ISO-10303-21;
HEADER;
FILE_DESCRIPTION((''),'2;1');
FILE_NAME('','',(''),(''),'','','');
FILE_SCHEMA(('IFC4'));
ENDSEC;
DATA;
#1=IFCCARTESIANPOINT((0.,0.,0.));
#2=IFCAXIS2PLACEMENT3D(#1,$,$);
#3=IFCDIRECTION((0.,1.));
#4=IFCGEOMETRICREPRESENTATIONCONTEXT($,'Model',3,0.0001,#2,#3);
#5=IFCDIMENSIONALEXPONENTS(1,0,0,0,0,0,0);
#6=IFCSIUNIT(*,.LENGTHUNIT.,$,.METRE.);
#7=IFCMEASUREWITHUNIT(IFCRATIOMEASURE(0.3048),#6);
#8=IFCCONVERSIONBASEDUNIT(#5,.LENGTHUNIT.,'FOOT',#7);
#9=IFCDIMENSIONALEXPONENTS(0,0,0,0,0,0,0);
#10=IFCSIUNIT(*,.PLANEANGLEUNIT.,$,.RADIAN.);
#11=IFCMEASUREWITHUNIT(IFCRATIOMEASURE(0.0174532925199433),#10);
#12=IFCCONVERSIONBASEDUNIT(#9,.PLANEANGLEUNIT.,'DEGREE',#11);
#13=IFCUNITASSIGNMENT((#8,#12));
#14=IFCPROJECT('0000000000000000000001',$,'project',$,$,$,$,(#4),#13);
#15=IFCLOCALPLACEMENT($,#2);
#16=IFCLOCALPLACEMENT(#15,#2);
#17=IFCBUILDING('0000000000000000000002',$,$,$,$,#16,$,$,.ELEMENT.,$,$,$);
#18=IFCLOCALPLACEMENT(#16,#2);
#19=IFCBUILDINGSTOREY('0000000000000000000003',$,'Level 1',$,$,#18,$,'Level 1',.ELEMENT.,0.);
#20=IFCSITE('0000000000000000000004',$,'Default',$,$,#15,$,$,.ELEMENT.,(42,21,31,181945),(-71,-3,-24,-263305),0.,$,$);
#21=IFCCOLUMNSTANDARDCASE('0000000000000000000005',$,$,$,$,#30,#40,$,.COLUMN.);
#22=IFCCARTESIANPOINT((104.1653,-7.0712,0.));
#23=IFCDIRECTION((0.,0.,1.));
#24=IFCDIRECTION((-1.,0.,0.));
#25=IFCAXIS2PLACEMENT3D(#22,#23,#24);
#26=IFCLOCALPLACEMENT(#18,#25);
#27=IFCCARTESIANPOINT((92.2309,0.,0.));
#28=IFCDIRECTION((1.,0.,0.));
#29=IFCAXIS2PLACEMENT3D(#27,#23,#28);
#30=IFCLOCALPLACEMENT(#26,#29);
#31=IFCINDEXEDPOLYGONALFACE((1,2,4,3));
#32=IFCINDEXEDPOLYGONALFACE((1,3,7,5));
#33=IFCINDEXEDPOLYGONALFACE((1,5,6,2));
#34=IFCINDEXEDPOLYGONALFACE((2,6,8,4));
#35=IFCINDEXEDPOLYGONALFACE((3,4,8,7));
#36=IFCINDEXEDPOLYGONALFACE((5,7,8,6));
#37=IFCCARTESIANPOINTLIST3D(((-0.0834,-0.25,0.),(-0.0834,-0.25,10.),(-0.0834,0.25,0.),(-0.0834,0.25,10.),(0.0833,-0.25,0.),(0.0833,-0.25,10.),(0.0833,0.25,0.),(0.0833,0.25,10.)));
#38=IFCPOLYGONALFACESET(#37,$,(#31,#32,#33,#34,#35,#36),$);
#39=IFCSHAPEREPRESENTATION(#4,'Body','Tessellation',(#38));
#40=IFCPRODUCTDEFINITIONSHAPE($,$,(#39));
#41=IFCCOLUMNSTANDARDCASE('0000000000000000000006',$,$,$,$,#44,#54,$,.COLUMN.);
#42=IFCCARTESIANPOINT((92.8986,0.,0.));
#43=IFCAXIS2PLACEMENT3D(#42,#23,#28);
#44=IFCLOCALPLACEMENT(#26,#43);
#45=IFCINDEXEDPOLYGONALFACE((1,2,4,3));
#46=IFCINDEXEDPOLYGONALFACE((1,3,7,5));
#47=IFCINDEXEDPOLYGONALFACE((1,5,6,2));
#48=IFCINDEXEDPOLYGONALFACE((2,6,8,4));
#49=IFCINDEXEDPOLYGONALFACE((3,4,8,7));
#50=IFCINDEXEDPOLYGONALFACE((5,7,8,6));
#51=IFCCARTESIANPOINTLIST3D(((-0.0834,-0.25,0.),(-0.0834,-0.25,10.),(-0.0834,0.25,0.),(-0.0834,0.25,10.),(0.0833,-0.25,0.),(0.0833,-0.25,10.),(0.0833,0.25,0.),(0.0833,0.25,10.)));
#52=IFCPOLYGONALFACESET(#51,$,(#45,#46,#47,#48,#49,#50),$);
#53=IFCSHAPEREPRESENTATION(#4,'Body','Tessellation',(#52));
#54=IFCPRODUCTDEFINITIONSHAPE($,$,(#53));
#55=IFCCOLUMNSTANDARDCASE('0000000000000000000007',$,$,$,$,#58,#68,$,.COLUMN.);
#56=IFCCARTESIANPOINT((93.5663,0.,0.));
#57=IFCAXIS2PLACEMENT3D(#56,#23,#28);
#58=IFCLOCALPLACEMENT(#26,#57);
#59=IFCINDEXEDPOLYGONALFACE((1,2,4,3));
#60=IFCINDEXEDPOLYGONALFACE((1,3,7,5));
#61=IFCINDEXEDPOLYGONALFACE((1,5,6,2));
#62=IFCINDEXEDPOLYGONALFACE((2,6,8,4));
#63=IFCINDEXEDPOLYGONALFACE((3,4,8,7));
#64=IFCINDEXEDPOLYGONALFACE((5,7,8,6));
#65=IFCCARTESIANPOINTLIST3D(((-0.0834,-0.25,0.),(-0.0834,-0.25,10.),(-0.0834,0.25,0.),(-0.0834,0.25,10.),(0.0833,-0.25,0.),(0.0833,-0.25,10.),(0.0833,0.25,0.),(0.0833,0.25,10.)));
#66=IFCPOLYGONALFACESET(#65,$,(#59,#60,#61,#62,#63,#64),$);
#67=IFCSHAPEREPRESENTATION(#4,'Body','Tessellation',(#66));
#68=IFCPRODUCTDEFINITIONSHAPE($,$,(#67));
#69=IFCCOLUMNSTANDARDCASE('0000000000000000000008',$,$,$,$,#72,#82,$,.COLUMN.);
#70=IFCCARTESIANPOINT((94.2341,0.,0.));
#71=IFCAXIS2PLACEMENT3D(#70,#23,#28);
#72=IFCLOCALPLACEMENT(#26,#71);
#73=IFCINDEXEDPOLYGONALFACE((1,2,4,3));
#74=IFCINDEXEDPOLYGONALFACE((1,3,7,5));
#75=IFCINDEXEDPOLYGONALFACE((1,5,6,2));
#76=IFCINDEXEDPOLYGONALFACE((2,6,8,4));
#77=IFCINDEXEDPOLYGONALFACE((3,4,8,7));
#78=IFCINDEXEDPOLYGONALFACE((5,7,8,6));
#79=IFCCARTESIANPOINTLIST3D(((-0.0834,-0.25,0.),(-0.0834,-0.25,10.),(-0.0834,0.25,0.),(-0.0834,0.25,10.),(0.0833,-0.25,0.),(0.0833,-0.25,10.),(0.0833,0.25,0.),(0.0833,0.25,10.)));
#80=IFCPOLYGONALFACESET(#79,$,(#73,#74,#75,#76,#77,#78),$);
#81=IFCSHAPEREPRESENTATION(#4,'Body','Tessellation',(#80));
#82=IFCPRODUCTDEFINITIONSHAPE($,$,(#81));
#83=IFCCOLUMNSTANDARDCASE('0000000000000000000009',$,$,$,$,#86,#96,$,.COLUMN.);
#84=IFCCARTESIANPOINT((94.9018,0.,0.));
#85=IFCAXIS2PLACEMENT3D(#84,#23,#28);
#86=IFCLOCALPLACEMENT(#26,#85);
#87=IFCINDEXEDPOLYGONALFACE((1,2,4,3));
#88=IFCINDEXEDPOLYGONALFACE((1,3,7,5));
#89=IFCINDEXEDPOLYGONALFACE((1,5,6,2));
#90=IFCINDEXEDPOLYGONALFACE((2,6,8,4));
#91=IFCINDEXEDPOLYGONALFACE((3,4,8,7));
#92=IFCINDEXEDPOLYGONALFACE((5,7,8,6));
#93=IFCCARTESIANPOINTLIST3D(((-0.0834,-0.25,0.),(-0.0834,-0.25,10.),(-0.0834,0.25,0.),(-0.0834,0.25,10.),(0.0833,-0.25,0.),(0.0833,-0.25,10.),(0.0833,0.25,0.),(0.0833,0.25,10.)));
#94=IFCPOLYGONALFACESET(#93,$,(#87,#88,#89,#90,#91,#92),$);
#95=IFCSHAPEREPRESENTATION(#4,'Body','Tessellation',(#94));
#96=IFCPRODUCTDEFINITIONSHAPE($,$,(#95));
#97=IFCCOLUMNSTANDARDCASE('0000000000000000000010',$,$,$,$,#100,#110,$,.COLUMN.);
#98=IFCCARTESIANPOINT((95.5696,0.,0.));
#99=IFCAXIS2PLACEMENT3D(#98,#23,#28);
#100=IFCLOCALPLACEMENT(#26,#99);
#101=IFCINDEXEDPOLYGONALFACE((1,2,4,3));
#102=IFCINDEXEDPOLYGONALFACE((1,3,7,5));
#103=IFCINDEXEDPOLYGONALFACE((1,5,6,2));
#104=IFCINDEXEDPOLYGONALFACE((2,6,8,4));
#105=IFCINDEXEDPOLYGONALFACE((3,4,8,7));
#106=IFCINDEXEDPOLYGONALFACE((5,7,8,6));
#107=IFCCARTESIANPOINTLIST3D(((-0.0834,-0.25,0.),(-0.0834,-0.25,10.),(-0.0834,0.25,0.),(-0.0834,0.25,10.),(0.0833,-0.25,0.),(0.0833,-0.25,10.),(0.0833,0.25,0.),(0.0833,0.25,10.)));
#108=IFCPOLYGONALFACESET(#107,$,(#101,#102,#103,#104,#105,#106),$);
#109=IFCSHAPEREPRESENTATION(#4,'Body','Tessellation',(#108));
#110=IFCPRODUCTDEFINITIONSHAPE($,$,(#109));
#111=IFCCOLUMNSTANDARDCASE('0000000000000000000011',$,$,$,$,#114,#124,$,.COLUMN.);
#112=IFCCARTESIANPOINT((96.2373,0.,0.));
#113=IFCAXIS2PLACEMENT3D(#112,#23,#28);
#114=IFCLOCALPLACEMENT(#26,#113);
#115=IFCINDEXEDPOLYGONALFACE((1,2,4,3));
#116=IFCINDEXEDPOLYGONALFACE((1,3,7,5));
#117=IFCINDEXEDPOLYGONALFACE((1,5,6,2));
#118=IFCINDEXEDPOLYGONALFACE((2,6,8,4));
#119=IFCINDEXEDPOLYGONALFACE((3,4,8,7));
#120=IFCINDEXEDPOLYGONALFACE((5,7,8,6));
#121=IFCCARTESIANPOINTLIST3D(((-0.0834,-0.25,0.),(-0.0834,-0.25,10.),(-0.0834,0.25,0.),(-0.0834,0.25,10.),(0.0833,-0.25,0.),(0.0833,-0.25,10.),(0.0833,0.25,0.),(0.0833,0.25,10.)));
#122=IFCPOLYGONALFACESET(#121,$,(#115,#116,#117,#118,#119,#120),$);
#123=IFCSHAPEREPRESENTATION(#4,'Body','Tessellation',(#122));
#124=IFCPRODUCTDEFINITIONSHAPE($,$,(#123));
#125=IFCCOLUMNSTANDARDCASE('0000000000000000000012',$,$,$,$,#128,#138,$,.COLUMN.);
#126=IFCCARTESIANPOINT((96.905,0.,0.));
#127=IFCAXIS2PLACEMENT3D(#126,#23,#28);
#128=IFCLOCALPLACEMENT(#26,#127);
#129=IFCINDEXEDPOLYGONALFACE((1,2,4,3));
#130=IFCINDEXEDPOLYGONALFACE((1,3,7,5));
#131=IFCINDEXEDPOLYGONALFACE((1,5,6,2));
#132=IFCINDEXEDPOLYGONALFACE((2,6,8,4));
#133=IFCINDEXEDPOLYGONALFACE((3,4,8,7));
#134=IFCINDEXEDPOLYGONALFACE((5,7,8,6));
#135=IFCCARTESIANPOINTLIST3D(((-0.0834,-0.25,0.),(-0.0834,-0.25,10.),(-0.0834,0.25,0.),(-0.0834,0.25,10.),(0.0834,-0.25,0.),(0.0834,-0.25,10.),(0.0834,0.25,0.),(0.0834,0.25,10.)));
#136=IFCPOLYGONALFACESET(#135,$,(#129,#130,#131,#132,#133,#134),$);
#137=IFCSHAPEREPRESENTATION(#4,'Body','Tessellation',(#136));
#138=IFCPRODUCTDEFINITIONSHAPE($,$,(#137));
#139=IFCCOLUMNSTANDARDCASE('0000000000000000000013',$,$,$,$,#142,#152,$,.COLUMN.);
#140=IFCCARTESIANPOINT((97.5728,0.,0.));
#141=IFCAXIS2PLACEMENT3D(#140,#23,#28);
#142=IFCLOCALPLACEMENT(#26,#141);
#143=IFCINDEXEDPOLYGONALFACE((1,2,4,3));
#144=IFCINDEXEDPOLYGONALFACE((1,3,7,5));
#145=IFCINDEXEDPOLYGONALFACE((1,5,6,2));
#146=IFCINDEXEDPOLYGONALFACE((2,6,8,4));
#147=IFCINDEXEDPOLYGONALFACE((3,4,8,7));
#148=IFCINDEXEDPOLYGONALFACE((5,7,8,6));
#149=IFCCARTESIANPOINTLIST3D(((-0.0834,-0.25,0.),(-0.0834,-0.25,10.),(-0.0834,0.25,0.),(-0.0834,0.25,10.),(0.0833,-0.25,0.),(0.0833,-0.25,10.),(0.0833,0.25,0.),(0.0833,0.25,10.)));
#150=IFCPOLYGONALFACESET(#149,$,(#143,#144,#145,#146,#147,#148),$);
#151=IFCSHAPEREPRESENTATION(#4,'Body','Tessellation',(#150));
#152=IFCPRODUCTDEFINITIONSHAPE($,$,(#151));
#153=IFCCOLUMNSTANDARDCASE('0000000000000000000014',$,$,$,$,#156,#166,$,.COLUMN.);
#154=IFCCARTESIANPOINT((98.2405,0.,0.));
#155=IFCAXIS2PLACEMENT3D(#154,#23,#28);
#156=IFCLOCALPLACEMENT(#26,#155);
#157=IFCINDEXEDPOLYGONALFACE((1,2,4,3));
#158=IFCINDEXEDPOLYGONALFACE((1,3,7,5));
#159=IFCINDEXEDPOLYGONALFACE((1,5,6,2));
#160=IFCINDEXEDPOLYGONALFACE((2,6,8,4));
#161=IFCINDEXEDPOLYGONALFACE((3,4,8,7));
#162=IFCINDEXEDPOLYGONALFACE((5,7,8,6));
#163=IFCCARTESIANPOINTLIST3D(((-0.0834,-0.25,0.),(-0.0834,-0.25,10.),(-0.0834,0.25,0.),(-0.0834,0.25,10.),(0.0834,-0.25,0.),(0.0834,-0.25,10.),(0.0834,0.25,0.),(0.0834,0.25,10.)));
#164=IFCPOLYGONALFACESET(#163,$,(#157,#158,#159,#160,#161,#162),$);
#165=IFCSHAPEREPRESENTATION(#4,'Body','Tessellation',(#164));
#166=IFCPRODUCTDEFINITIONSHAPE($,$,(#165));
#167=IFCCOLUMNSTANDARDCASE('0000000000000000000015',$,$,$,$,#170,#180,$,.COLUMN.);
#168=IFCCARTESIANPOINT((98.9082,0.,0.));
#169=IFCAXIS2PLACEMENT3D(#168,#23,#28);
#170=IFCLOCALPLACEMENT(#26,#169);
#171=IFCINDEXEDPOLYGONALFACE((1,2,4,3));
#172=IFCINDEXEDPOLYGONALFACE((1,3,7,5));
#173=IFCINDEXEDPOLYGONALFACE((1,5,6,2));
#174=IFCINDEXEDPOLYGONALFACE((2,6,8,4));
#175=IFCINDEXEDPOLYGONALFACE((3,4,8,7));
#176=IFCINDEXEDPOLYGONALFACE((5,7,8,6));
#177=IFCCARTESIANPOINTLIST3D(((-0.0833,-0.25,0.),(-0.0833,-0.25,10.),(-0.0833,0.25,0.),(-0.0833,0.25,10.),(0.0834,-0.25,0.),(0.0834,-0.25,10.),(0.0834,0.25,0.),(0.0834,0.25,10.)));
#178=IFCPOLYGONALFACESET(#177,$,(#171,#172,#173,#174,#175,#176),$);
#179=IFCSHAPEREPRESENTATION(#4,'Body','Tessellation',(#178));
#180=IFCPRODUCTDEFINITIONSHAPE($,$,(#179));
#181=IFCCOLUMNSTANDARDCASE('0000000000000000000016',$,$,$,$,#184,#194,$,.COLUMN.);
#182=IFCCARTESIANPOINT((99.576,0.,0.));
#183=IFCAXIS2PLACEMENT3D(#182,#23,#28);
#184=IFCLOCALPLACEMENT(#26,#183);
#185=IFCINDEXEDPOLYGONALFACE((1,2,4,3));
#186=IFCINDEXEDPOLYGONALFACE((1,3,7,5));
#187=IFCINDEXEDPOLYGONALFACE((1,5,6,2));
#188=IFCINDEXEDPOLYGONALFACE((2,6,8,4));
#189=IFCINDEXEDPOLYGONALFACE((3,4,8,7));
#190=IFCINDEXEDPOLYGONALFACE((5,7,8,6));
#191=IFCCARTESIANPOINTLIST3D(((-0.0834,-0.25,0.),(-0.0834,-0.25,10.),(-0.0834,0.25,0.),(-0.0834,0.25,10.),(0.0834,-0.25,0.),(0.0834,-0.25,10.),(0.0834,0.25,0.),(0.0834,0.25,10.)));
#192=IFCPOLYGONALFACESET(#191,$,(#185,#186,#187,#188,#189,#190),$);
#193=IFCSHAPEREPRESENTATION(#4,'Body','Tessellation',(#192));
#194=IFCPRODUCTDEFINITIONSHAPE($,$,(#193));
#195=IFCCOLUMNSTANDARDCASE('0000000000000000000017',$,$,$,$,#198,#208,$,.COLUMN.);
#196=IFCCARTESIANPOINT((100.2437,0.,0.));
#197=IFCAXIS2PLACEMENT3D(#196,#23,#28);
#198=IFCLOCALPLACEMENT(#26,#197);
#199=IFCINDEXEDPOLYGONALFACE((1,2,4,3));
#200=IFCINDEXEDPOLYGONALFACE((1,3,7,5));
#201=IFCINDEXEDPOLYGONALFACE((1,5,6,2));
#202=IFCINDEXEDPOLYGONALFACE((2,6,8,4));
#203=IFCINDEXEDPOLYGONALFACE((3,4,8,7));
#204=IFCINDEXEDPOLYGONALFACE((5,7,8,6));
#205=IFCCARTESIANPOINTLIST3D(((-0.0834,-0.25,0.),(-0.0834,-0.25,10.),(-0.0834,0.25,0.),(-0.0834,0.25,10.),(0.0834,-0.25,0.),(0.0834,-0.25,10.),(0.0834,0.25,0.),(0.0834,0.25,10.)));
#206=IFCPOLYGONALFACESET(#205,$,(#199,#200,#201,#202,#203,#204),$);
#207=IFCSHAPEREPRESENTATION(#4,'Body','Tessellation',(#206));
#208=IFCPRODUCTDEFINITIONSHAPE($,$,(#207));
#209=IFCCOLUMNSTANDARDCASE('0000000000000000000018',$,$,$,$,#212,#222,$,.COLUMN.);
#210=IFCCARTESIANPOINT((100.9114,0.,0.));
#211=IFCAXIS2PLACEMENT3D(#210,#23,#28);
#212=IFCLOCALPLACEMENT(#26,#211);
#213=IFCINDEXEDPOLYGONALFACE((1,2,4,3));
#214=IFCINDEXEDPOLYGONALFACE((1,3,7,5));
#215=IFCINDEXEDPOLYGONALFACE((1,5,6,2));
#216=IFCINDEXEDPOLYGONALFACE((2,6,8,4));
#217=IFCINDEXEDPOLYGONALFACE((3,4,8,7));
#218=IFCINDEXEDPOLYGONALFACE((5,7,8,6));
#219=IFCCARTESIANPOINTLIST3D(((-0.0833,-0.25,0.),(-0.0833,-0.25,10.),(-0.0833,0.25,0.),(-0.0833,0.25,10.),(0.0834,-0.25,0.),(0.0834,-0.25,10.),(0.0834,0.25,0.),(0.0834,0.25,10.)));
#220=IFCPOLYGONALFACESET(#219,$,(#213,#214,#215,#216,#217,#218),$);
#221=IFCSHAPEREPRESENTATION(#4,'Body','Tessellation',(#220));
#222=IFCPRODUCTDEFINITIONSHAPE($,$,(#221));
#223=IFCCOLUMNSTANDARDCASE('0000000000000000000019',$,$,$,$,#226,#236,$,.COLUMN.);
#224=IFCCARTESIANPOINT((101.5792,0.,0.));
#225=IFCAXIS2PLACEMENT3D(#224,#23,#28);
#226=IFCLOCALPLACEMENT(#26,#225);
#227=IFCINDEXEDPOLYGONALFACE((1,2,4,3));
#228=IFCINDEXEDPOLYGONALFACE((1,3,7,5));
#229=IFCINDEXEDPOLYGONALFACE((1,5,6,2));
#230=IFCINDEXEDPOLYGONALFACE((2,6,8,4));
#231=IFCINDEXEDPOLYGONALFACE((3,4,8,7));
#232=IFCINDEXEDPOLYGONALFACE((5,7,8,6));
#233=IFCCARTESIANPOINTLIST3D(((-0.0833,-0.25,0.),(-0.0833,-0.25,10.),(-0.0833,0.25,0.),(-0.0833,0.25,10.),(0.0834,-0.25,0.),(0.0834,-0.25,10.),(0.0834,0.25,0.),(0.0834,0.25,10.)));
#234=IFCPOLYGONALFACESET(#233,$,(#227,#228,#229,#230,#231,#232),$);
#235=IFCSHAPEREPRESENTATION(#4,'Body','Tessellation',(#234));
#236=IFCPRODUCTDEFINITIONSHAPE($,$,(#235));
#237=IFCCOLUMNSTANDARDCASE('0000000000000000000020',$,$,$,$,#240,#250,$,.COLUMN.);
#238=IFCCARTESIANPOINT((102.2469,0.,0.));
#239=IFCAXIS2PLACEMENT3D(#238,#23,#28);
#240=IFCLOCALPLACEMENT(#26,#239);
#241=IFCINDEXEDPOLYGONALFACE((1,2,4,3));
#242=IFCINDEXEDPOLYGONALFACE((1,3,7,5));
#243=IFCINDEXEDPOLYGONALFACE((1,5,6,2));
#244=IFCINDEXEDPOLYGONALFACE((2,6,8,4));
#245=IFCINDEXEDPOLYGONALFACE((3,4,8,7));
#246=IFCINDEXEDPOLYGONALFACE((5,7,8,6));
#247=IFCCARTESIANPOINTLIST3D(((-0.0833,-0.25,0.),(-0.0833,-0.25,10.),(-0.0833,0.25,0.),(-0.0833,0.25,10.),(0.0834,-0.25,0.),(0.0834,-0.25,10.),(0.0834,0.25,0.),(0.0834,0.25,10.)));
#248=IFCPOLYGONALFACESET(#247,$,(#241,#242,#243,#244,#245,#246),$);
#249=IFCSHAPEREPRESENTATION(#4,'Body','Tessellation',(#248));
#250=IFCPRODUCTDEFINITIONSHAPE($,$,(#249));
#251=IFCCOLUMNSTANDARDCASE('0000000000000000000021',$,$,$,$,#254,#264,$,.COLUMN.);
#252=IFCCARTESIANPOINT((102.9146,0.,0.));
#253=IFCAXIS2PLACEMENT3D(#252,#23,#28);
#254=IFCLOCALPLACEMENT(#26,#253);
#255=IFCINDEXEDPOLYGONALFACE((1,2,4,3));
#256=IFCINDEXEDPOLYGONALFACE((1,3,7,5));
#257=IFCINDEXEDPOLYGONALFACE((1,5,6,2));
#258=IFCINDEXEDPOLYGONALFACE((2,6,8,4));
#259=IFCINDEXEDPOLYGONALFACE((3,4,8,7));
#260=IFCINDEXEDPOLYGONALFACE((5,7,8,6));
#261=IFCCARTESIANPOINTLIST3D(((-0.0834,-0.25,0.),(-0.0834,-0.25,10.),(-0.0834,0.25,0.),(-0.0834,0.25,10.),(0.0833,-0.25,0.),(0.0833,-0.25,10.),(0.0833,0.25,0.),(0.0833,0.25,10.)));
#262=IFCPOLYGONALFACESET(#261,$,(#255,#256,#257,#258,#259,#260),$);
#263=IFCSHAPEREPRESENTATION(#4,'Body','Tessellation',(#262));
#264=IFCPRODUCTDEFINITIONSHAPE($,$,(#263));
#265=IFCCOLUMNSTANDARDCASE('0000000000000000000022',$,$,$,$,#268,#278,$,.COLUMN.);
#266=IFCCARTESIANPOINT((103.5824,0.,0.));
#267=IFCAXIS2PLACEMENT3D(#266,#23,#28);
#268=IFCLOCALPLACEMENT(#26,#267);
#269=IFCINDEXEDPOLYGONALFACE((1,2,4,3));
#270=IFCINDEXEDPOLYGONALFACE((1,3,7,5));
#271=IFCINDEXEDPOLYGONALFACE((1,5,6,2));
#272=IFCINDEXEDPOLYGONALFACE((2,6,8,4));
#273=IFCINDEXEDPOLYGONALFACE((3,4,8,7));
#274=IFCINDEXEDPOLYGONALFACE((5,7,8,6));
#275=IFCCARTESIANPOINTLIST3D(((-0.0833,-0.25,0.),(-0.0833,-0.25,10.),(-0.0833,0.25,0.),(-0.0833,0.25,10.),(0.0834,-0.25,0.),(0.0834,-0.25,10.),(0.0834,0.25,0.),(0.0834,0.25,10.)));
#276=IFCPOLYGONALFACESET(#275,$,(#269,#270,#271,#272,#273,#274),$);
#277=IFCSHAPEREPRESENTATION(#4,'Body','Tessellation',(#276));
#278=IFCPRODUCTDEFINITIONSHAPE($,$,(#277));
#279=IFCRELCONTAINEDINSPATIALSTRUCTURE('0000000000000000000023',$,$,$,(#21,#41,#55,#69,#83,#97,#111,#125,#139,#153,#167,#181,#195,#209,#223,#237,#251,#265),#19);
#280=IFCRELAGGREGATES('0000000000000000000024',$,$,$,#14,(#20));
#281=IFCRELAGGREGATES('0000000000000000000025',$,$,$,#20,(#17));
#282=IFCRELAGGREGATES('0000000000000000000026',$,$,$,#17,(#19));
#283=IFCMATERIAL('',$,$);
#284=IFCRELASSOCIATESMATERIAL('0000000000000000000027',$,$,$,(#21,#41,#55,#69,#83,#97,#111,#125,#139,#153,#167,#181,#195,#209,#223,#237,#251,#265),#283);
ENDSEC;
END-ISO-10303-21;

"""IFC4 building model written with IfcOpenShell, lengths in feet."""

from ifc_helpers import new_model, entity, si_unit, converted_unit, direction, frame, origin, place, context, project, spatial, rectangle, extrude, material, element, save


model = new_model("IFC4")

# Units and contexts
model_context = context("Model", 3, precision=0.0001, world=origin(), true_north=direction((0.0, 1.0)))
ifc_project = project(units=[converted_unit("LENGTHUNIT", "FOOT", entity("IfcRatioMeasure", 0.3048), si_unit("LENGTHUNIT", "METRE"), dimensions=[1, 0, 0, 0, 0, 0, 0]), converted_unit("PLANEANGLEUNIT", "DEGREE", entity("IfcRatioMeasure", 0.0174532925199433), si_unit("PLANEANGLEUNIT", "RADIAN"), dimensions=[0, 0, 0, 0, 0, 0, 0])], contexts=[model_context])

# Site, building, storey
site_placement = place(None, origin())
site = spatial("IfcSite", under=ifc_project, at=site_placement, Name="Default", CompositionType="ELEMENT", RefLatitude=(42, 21, 31, 181945), RefLongitude=(-71, -3, -24, -263305), RefElevation=0.0)
building_placement = place(site_placement, origin())
building = spatial("IfcBuilding", under=site, at=building_placement, CompositionType="ELEMENT")
storey_placement = place(building_placement, origin())
storey = spatial("IfcBuildingStorey", under=building, at=storey_placement, Name="Level 1", LongName="Level 1", CompositionType="ELEMENT", Elevation=0.0)

# Columns
ifc_material_1 = material(Name="")
placement_1 = place(storey_placement, frame((104.1653, -7.0712, 0.0), z_axis=(0.0, 0.0, 1.0), x_axis=(-1.0, 0.0, 0.0)))
for number, where, z_axis, x_axis in (
    (1, (92.2309, 0.0, 0.0), (0.0, 0.0, 1.0), (1.0, 0.0, 0.0)),
    (2, (92.8986, 0.0, 0.0), (0.0, 0.0, 1.0), (1.0, 0.0, 0.0)),
    (3, (93.5663, 0.0, 0.0), (0.0, 0.0, 1.0), (1.0, 0.0, 0.0)),
    (4, (94.2341, 0.0, 0.0), (0.0, 0.0, 1.0), (1.0, 0.0, 0.0)),
    (5, (94.9018, 0.0, 0.0), (0.0, 0.0, 1.0), (1.0, 0.0, 0.0)),
    (6, (95.5696, 0.0, 0.0), (0.0, 0.0, 1.0), (1.0, 0.0, 0.0)),
    (7, (96.2373, 0.0, 0.0), (0.0, 0.0, 1.0), (1.0, 0.0, 0.0)),
    (8, (96.905, 0.0, 0.0), (0.0, 0.0, 1.0), (1.0, 0.0, 0.0)),
    (9, (97.5728, 0.0, 0.0), (0.0, 0.0, 1.0), (1.0, 0.0, 0.0)),
    (10, (98.2405, 0.0, 0.0), (0.0, 0.0, 1.0), (1.0, 0.0, 0.0)),
    (11, (98.9082, 0.0, 0.0), (0.0, 0.0, 1.0), (1.0, 0.0, 0.0)),
    (12, (99.576, 0.0, 0.0), (0.0, 0.0, 1.0), (1.0, 0.0, 0.0)),
    (13, (100.2437, 0.0, 0.0), (0.0, 0.0, 1.0), (1.0, 0.0, 0.0)),
    (14, (100.9114, 0.0, 0.0), (0.0, 0.0, 1.0), (1.0, 0.0, 0.0)),
    (15, (101.5792, 0.0, 0.0), (0.0, 0.0, 1.0), (1.0, 0.0, 0.0)),
    (16, (102.2469, 0.0, 0.0), (0.0, 0.0, 1.0), (1.0, 0.0, 0.0)),
    (17, (102.9146, 0.0, 0.0), (0.0, 0.0, 1.0), (1.0, 0.0, 0.0)),
    (18, (103.5824, 0.0, 0.0), (0.0, 0.0, 1.0), (1.0, 0.0, 0.0)),
):
    element("IfcColumnStandardCase", number, at=place(placement_1, frame(where, z_axis=z_axis, x_axis=x_axis)), inside=storey, material=ifc_material_1, PredefinedType="COLUMN", context=model_context, shape_type="SweptSolid", body=[
        extrude(rectangle(XDim=0.1667, YDim=0.5), origin(), (0.0, 0.0, 1.0), 10.0),
    ])

save(model, "model.ifc")
